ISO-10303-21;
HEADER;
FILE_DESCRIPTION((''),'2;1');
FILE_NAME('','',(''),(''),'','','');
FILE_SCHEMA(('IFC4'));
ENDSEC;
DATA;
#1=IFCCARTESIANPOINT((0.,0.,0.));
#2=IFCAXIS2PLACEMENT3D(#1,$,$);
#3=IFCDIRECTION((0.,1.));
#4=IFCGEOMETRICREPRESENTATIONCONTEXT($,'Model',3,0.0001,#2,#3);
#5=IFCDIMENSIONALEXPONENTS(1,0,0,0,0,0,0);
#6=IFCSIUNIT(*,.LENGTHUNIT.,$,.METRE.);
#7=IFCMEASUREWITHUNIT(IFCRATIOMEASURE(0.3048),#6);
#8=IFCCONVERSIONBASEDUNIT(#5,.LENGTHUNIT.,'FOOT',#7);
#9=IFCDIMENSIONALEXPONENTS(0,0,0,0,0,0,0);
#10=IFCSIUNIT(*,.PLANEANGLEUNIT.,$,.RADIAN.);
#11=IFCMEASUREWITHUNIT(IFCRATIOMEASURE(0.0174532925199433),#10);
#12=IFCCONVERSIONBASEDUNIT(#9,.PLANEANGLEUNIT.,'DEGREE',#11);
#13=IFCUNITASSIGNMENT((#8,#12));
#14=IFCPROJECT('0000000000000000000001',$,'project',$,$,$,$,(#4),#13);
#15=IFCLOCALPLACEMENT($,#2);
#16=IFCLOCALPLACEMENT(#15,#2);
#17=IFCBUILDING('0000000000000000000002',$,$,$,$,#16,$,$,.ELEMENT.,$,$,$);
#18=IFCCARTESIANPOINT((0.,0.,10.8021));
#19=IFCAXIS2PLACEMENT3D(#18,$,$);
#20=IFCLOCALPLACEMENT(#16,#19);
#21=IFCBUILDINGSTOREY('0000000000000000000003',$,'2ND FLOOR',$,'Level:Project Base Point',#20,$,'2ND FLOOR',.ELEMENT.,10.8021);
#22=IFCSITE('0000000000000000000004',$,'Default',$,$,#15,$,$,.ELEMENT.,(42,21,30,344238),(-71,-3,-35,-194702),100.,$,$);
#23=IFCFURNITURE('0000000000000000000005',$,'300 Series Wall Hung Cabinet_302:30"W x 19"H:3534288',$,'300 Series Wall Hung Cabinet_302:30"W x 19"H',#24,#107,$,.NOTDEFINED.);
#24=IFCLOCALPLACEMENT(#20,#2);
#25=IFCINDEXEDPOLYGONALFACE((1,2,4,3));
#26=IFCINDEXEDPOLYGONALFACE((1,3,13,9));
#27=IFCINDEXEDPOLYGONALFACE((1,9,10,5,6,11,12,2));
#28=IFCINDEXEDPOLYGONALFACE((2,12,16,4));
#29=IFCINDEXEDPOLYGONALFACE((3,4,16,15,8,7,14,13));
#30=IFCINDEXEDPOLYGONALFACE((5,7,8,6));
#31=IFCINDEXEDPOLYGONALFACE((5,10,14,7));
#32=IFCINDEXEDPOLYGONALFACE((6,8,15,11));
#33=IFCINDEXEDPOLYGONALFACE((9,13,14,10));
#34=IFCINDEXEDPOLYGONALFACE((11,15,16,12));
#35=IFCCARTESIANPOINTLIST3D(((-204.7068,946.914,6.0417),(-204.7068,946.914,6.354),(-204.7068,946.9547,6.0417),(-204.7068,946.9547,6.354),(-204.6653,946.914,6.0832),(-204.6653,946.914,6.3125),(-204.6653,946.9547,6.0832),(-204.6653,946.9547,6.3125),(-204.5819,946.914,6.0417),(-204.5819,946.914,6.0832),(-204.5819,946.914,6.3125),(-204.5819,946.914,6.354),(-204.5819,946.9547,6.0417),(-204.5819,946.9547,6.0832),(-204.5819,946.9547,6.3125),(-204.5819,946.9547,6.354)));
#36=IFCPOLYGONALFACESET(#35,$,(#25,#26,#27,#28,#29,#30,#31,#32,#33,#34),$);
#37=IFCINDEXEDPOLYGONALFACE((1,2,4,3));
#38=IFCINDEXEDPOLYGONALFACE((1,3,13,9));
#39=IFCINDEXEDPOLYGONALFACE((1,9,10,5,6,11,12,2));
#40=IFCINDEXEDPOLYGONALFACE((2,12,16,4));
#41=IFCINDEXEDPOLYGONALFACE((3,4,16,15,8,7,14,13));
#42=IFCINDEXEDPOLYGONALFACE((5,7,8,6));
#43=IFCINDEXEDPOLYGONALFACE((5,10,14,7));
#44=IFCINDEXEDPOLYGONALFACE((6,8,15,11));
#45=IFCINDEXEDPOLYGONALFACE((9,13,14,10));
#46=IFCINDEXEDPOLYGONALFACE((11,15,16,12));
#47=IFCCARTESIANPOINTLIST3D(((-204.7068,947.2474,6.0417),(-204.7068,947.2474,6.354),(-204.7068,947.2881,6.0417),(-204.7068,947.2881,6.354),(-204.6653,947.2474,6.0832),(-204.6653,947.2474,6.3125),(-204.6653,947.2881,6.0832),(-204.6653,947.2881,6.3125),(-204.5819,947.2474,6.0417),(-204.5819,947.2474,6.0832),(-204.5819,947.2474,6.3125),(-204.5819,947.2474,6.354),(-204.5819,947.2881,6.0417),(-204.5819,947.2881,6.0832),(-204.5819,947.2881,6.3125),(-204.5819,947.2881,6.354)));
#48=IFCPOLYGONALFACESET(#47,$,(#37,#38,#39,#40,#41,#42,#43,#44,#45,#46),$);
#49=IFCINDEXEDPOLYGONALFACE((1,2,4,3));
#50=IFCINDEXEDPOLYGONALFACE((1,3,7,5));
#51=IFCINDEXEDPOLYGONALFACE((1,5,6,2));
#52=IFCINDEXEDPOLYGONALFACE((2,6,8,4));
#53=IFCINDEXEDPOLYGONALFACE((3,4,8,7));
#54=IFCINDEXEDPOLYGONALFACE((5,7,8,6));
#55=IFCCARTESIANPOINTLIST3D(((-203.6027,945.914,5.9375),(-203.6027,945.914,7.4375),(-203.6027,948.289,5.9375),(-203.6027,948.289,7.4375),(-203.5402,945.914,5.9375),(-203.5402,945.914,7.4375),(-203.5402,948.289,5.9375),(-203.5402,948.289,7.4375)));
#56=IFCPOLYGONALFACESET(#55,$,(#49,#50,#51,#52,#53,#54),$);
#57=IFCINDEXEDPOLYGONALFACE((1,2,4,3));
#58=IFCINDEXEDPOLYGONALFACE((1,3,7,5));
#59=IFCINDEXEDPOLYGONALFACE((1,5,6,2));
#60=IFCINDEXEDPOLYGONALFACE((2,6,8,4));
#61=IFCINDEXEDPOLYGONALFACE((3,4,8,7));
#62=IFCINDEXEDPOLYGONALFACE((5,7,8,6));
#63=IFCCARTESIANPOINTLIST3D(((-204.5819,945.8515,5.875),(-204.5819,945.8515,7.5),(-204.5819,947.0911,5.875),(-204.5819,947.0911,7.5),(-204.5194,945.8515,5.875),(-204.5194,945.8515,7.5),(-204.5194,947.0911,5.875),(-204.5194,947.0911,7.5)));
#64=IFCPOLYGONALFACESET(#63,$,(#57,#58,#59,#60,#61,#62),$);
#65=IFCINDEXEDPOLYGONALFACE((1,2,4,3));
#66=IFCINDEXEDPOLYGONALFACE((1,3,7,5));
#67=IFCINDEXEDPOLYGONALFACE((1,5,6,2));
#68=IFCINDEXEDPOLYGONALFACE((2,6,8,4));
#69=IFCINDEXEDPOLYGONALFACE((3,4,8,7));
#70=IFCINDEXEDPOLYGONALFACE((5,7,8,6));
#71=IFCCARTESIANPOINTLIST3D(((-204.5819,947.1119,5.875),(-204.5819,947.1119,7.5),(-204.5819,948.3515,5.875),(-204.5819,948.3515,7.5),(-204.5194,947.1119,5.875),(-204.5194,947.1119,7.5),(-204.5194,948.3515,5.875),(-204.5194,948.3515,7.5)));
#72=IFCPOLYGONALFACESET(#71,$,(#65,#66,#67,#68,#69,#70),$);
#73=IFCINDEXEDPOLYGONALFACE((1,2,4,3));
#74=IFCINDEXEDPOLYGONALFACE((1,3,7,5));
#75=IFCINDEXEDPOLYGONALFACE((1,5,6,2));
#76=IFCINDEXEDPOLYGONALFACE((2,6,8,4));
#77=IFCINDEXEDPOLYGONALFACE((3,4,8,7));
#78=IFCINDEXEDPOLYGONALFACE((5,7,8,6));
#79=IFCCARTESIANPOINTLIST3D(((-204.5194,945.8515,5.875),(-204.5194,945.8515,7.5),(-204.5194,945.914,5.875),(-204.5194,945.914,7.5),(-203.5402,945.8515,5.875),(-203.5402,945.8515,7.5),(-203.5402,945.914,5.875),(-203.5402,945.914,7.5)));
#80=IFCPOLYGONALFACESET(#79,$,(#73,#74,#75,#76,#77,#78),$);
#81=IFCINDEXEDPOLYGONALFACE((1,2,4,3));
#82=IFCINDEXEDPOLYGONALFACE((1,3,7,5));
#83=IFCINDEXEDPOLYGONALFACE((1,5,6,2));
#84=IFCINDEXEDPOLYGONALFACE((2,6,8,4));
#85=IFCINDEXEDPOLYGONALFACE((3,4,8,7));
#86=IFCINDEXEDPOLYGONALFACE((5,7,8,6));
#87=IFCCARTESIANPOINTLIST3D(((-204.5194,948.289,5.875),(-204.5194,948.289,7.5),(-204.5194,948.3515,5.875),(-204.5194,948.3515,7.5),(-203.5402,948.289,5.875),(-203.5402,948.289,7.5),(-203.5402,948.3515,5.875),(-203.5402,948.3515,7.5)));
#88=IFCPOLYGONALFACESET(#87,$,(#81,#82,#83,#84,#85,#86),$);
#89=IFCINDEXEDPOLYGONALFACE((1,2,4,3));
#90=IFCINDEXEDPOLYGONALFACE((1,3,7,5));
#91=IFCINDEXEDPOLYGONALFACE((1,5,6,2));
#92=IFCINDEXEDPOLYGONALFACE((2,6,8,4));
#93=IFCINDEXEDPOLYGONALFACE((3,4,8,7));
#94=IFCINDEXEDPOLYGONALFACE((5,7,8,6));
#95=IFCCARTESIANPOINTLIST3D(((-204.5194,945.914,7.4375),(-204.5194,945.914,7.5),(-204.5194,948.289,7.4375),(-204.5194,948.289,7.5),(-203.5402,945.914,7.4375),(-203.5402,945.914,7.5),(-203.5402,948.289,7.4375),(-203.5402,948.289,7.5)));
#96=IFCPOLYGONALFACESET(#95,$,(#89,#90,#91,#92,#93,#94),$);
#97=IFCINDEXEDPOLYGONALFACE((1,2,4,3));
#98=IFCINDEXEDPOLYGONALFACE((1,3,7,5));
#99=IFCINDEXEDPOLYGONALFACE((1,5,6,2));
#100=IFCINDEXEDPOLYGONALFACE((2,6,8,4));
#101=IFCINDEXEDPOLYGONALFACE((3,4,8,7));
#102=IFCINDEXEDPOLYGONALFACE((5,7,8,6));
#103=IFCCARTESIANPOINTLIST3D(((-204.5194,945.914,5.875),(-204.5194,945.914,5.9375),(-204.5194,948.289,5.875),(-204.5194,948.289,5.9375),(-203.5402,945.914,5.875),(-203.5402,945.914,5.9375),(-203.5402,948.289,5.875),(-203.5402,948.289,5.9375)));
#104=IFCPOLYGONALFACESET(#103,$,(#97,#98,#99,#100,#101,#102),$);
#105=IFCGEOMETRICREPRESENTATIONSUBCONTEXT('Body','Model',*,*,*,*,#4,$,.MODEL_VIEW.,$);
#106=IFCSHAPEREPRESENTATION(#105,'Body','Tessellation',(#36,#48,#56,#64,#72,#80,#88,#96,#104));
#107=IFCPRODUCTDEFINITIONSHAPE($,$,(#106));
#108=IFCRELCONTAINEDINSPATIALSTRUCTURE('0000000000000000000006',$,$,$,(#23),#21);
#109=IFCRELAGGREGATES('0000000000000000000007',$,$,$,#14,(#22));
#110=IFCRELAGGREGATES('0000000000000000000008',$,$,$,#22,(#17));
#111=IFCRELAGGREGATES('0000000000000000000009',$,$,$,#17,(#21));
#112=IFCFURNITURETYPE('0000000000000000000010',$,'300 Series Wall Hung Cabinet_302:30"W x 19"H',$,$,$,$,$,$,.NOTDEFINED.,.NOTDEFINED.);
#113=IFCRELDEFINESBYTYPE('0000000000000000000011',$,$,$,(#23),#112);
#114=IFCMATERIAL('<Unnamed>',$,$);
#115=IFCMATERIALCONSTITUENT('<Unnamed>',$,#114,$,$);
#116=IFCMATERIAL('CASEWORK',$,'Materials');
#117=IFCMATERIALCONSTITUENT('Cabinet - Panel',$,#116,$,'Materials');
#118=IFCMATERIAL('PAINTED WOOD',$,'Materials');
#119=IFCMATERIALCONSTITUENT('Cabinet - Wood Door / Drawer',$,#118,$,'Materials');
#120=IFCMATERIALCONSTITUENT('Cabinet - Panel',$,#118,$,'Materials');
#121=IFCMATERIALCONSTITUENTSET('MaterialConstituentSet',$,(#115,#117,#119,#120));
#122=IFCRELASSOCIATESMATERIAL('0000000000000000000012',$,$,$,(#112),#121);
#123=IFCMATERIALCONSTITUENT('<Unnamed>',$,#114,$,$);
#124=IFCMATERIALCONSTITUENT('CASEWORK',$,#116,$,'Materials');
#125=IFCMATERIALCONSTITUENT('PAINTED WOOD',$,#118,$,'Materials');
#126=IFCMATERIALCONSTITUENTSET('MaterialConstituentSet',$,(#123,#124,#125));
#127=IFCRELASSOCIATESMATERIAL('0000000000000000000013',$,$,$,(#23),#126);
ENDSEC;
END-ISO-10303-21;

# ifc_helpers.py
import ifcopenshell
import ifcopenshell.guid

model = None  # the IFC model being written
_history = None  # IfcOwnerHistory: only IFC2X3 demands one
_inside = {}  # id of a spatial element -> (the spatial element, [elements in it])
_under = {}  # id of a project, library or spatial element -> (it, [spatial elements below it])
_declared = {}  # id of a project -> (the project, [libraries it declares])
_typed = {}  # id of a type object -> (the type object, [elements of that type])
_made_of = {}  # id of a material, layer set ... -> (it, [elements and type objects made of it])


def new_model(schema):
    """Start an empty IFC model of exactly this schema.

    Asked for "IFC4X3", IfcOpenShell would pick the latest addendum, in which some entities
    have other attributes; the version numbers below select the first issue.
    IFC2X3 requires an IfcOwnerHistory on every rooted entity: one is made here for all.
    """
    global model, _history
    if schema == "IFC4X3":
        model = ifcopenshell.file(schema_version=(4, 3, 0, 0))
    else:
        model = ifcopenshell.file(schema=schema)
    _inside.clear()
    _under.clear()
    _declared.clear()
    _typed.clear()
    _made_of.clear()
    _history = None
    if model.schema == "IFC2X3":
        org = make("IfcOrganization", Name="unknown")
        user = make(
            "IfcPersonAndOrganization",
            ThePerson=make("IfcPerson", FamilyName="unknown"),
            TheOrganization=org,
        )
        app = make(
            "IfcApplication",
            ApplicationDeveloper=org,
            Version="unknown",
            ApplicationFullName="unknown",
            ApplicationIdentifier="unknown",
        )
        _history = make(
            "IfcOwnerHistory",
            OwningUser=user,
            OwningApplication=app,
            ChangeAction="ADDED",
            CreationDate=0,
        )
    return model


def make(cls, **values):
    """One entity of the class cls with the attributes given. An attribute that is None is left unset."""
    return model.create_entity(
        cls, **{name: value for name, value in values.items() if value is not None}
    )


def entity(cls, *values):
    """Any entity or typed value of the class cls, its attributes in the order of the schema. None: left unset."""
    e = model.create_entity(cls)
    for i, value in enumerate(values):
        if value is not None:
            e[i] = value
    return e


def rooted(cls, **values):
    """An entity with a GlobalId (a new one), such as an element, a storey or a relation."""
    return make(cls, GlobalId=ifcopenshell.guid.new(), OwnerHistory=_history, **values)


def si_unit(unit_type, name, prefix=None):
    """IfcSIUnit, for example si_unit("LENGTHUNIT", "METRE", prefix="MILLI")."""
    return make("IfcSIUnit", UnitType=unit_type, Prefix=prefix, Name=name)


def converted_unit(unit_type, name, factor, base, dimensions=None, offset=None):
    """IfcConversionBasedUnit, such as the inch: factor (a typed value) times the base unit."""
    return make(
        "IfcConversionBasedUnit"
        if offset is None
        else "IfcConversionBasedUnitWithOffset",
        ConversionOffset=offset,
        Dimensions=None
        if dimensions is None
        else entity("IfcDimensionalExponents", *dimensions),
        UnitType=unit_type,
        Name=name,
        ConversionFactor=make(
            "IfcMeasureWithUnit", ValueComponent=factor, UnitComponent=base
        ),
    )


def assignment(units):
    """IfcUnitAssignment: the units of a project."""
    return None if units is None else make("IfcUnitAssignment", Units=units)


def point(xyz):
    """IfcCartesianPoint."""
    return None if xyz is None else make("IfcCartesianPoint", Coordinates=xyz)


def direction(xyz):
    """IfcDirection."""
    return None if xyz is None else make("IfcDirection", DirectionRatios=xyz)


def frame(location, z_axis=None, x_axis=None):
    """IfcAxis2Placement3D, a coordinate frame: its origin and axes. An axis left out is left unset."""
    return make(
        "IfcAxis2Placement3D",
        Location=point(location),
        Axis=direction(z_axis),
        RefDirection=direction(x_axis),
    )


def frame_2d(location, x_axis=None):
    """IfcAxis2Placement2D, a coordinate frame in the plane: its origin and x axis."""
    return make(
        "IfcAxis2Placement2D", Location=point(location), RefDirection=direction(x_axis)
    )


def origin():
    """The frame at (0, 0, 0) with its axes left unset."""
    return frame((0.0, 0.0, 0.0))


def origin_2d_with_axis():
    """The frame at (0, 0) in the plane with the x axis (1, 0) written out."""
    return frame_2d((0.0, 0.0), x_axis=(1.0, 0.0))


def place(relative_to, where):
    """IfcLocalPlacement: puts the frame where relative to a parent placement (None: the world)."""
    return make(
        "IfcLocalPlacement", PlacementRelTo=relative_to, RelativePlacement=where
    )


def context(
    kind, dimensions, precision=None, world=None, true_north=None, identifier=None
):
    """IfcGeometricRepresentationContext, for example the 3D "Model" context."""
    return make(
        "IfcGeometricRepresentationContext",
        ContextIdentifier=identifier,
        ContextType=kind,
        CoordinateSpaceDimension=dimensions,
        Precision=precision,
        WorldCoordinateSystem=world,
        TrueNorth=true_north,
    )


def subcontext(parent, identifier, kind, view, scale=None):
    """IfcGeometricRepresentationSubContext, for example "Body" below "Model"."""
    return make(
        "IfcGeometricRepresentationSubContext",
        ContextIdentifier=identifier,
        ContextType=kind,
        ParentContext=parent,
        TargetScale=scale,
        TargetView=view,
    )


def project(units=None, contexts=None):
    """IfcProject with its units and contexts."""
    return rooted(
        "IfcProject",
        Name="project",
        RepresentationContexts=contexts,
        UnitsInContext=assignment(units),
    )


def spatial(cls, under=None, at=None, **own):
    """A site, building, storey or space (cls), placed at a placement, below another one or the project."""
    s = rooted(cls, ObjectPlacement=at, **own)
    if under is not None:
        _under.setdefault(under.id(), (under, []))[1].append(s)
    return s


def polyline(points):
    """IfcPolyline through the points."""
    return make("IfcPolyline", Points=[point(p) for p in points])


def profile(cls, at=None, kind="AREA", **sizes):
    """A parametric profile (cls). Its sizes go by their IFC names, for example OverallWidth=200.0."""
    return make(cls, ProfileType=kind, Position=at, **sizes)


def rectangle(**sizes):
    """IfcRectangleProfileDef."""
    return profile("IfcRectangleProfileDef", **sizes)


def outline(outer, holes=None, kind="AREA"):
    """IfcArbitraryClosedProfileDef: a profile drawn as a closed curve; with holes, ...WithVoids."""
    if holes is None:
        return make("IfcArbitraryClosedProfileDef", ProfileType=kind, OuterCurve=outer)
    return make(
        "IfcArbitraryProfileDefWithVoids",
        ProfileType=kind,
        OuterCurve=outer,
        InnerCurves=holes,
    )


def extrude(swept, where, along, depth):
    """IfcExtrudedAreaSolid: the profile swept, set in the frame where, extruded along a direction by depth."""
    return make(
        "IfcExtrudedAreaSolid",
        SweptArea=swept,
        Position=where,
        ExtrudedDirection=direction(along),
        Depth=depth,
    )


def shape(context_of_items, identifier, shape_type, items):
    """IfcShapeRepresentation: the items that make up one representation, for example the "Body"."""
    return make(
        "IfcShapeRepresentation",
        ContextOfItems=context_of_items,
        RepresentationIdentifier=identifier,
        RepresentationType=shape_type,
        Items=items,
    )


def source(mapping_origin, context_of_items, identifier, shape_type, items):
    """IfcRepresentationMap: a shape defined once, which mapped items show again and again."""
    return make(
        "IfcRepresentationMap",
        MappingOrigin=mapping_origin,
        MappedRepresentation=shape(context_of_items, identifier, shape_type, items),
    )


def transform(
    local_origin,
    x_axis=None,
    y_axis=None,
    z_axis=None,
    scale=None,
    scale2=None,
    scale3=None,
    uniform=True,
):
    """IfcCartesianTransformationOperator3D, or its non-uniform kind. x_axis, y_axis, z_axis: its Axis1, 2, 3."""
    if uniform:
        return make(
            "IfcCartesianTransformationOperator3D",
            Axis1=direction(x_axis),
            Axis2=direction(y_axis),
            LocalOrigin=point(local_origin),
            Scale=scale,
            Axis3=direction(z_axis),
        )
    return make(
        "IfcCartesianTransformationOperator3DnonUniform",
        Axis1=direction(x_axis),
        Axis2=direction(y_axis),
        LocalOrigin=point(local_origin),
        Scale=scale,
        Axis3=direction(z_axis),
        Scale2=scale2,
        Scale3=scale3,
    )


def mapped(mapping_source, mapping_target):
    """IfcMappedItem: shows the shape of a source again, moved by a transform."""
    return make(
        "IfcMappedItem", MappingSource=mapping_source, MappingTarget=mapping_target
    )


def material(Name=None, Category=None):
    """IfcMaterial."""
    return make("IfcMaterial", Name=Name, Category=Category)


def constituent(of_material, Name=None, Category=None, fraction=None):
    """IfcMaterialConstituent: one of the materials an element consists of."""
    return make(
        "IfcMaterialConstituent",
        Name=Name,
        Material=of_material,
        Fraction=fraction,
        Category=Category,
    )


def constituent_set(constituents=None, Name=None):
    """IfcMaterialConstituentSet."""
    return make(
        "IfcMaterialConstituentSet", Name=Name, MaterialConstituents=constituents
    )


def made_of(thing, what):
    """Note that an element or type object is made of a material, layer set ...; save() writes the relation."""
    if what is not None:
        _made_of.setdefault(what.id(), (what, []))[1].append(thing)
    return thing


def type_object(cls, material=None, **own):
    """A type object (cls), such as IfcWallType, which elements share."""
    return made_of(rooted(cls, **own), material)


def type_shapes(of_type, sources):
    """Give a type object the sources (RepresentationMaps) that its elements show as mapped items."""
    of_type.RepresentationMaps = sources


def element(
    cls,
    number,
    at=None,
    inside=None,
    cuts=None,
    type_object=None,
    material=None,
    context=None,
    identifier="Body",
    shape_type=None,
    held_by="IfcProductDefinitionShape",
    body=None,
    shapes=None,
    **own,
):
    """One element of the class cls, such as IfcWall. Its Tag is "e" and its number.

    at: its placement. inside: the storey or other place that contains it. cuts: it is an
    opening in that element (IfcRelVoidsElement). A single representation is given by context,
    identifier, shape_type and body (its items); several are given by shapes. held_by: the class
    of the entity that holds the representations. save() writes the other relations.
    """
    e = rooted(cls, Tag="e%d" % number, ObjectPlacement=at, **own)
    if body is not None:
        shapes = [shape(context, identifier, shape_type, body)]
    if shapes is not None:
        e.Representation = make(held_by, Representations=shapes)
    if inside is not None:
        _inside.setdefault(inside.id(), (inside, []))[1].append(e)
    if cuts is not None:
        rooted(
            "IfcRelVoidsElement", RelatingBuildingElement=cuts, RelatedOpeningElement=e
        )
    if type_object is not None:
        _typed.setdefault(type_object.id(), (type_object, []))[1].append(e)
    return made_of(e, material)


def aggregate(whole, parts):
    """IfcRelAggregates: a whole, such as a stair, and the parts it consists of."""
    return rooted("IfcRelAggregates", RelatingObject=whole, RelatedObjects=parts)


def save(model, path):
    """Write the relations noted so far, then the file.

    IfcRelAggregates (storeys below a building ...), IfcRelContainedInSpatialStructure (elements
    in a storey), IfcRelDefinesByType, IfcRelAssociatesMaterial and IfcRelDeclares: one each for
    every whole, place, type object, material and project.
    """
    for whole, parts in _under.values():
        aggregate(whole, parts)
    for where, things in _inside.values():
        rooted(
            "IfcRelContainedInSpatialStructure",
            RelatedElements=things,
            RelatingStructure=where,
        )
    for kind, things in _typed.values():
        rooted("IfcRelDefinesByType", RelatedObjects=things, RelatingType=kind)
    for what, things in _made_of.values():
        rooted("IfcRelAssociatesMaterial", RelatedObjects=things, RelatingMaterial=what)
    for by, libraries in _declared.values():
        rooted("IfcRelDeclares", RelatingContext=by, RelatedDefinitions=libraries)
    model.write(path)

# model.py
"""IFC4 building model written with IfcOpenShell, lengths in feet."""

from ifc_helpers import new_model, entity, si_unit, converted_unit, direction, frame, frame_2d, origin, origin_2d_with_axis, place, context, subcontext, project, spatial, polyline, rectangle, outline, extrude, source, transform, mapped, material, constituent, constituent_set, type_object, type_shapes, element, save


model = new_model("IFC4")

# Units and contexts
model_context = context("Model", 3, precision=0.0001, world=origin(), true_north=direction((0.0, 1.0)))
body_context = subcontext(model_context, "Body", "Model", "MODEL_VIEW")
ifc_project = project(units=[converted_unit("LENGTHUNIT", "FOOT", entity("IfcRatioMeasure", 0.3048), si_unit("LENGTHUNIT", "METRE"), dimensions=[1, 0, 0, 0, 0, 0, 0]), converted_unit("PLANEANGLEUNIT", "DEGREE", entity("IfcRatioMeasure", 0.0174532925199433), si_unit("PLANEANGLEUNIT", "RADIAN"), dimensions=[0, 0, 0, 0, 0, 0, 0])], contexts=[model_context])

# Site, building, storey
site_placement = place(None, origin())
site = spatial("IfcSite", under=ifc_project, at=site_placement, Name="Default", CompositionType="ELEMENT", RefLatitude=(42, 21, 30, 344238), RefLongitude=(-71, -3, -35, -194702), RefElevation=100.0)
building_placement = place(site_placement, origin())
building = spatial("IfcBuilding", under=site, at=building_placement, CompositionType="ELEMENT")
storey_placement = place(building_placement, frame((0.0, 0.0, 10.8021)))
storey = spatial("IfcBuildingStorey", under=building, at=storey_placement, Name="2ND FLOOR", ObjectType="Level:Project Base Point", LongName="2ND FLOOR", CompositionType="ELEMENT", Elevation=10.8021)

# Furniture
ifc_material_1 = material(Name="<Unnamed>")
ifc_material_2 = material(Name="CASEWORK", Category="Materials")
ifc_material_3 = material(Name="PAINTED WOOD", Category="Materials")
ifc_constituent_1 = constituent(ifc_material_1, Name="<Unnamed>")
ifc_constituent_2 = constituent(ifc_material_2, Name="CASEWORK", Category="Materials")
ifc_constituent_3 = constituent(ifc_material_3, Name="PAINTED WOOD", Category="Materials")
ifc_constituent_set_1 = constituent_set(constituents=[ifc_constituent_1, ifc_constituent_2, ifc_constituent_3], Name="MaterialConstituentSet")
ifc_constituent_4 = constituent(ifc_material_1, Name="<Unnamed>")
ifc_constituent_5 = constituent(ifc_material_2, Name="Cabinet - Panel", Category="Materials")
ifc_constituent_6 = constituent(ifc_material_3, Name="Cabinet - Wood Door / Drawer", Category="Materials")
ifc_constituent_7 = constituent(ifc_material_3, Name="Cabinet - Panel", Category="Materials")
ifc_constituent_set_2 = constituent_set(constituents=[ifc_constituent_4, ifc_constituent_5, ifc_constituent_6, ifc_constituent_7], Name="MaterialConstituentSet")
furniture_type_1 = type_object("IfcFurnitureType", Name="300 Series Wall Hung Cabinet_302:30\"W x 19\"H", AssemblyPlace="NOTDEFINED", PredefinedType="NOTDEFINED", material=ifc_constituent_set_2)
shared_shape_1 = source(origin(), body_context, "Body", "SweptSolid", [
    extrude(outline(polyline([(-0.0521, -0.1146), (-0.0521, -0.1562), (0.0729, -0.1562), (0.0729, 0.1562), (-0.0521, 0.1562), (-0.0521, 0.1146), (0.0313, 0.1146), (0.0313, -0.1146), (-0.0521, -0.1146)])), frame((1.0625, 1.0937, 0.3229), z_axis=(-1.0, 0.0, 0.0), x_axis=(0.0, 1.0, 0.0)), (0.0, 0.0, -1.0), 0.0407),
    extrude(outline(polyline([(-0.0521, -0.1146), (-0.0521, -0.1562), (0.0729, -0.1562), (0.0729, 0.1562), (-0.0521, 0.1562), (-0.0521, 0.1146), (0.0313, 0.1146), (0.0313, -0.1146), (-0.0521, -0.1146)])), frame((1.3958, 1.0937, 0.3229), z_axis=(-1.0, 0.0, 0.0), x_axis=(0.0, 1.0, 0.0)), (0.0, 0.0, -1.0), 0.0407),
    extrude(rectangle(XDim=0.0625, YDim=2.375, at=frame_2d((0.0, 0.0), x_axis=(1.0, 0.0))), frame((1.25, 0.0313, 0.0625), z_axis=(0.0, 0.0, 1.0), x_axis=(0.0, 1.0, 0.0)), (0.0, 0.0, 1.0), 1.5),
    extrude(rectangle(XDim=0.0625, YDim=1.2396, at=origin_2d_with_axis()), frame((0.6198, 1.0104, 0.0), z_axis=(0.0, 0.0, 1.0), x_axis=(0.0, 1.0, 0.0)), (0.0, 0.0, 1.0), 1.625),
    extrude(rectangle(XDim=0.0625, YDim=1.2396, at=frame_2d((0.0, 0.0), x_axis=(1.0, 0.0))), frame((1.8802, 1.0104, 0.0), z_axis=(0.0, 0.0, 1.0), x_axis=(0.0, 1.0, 0.0)), (0.0, 0.0, 1.0), 1.625),
    extrude(rectangle(XDim=0.0625, YDim=0.9792, at=frame_2d((0.0, 0.0), x_axis=(1.0, 0.0))), frame((0.0313, 0.4896, 0.0)), (0.0, 0.0, 1.0), 1.625),
    extrude(rectangle(XDim=0.0625, YDim=0.9792, at=frame_2d((0.0, 0.0), x_axis=(1.0, 0.0))), frame((2.4688, 0.4896, 0.0)), (0.0, 0.0, 1.0), 1.625),
    extrude(rectangle(XDim=2.375, YDim=0.9792, at=frame_2d((0.0, 0.0), x_axis=(1.0, 0.0))), frame((1.25, 0.4896, 1.5625), z_axis=(0.0, 0.0, 1.0), x_axis=(-1.0, 0.0, 0.0)), (0.0, 0.0, 1.0), 0.0625),
    extrude(rectangle(XDim=2.375, YDim=0.9792, at=frame_2d((0.0, 0.0), x_axis=(1.0, 0.0))), frame((1.25, 0.4896, 0.0), z_axis=(0.0, 0.0, 1.0), x_axis=(-1.0, 0.0, 0.0)), (0.0, 0.0, 1.0), 0.0625),
])
type_shapes(furniture_type_1, [shared_shape_1])
furniture_1_placement = place(storey_placement, frame((-203.5402, 945.8515, 5.875), z_axis=(0.0, 0.0, 1.0), x_axis=(0.0, 1.0, 0.0)))
element("IfcFurniture", 1, at=furniture_1_placement, inside=storey, type_object=furniture_type_1, material=ifc_constituent_set_1, Name="300 Series Wall Hung Cabinet_302:30\"W x 19\"H:3534288", ObjectType="300 Series Wall Hung Cabinet_302:30\"W x 19\"H", PredefinedType="NOTDEFINED", context=body_context, shape_type="MappedRepresentation", body=[
    mapped(shared_shape_1, transform((0.0, 0.0, 0.0), scale=1.0)),
])

save(model, "model.ifc")
